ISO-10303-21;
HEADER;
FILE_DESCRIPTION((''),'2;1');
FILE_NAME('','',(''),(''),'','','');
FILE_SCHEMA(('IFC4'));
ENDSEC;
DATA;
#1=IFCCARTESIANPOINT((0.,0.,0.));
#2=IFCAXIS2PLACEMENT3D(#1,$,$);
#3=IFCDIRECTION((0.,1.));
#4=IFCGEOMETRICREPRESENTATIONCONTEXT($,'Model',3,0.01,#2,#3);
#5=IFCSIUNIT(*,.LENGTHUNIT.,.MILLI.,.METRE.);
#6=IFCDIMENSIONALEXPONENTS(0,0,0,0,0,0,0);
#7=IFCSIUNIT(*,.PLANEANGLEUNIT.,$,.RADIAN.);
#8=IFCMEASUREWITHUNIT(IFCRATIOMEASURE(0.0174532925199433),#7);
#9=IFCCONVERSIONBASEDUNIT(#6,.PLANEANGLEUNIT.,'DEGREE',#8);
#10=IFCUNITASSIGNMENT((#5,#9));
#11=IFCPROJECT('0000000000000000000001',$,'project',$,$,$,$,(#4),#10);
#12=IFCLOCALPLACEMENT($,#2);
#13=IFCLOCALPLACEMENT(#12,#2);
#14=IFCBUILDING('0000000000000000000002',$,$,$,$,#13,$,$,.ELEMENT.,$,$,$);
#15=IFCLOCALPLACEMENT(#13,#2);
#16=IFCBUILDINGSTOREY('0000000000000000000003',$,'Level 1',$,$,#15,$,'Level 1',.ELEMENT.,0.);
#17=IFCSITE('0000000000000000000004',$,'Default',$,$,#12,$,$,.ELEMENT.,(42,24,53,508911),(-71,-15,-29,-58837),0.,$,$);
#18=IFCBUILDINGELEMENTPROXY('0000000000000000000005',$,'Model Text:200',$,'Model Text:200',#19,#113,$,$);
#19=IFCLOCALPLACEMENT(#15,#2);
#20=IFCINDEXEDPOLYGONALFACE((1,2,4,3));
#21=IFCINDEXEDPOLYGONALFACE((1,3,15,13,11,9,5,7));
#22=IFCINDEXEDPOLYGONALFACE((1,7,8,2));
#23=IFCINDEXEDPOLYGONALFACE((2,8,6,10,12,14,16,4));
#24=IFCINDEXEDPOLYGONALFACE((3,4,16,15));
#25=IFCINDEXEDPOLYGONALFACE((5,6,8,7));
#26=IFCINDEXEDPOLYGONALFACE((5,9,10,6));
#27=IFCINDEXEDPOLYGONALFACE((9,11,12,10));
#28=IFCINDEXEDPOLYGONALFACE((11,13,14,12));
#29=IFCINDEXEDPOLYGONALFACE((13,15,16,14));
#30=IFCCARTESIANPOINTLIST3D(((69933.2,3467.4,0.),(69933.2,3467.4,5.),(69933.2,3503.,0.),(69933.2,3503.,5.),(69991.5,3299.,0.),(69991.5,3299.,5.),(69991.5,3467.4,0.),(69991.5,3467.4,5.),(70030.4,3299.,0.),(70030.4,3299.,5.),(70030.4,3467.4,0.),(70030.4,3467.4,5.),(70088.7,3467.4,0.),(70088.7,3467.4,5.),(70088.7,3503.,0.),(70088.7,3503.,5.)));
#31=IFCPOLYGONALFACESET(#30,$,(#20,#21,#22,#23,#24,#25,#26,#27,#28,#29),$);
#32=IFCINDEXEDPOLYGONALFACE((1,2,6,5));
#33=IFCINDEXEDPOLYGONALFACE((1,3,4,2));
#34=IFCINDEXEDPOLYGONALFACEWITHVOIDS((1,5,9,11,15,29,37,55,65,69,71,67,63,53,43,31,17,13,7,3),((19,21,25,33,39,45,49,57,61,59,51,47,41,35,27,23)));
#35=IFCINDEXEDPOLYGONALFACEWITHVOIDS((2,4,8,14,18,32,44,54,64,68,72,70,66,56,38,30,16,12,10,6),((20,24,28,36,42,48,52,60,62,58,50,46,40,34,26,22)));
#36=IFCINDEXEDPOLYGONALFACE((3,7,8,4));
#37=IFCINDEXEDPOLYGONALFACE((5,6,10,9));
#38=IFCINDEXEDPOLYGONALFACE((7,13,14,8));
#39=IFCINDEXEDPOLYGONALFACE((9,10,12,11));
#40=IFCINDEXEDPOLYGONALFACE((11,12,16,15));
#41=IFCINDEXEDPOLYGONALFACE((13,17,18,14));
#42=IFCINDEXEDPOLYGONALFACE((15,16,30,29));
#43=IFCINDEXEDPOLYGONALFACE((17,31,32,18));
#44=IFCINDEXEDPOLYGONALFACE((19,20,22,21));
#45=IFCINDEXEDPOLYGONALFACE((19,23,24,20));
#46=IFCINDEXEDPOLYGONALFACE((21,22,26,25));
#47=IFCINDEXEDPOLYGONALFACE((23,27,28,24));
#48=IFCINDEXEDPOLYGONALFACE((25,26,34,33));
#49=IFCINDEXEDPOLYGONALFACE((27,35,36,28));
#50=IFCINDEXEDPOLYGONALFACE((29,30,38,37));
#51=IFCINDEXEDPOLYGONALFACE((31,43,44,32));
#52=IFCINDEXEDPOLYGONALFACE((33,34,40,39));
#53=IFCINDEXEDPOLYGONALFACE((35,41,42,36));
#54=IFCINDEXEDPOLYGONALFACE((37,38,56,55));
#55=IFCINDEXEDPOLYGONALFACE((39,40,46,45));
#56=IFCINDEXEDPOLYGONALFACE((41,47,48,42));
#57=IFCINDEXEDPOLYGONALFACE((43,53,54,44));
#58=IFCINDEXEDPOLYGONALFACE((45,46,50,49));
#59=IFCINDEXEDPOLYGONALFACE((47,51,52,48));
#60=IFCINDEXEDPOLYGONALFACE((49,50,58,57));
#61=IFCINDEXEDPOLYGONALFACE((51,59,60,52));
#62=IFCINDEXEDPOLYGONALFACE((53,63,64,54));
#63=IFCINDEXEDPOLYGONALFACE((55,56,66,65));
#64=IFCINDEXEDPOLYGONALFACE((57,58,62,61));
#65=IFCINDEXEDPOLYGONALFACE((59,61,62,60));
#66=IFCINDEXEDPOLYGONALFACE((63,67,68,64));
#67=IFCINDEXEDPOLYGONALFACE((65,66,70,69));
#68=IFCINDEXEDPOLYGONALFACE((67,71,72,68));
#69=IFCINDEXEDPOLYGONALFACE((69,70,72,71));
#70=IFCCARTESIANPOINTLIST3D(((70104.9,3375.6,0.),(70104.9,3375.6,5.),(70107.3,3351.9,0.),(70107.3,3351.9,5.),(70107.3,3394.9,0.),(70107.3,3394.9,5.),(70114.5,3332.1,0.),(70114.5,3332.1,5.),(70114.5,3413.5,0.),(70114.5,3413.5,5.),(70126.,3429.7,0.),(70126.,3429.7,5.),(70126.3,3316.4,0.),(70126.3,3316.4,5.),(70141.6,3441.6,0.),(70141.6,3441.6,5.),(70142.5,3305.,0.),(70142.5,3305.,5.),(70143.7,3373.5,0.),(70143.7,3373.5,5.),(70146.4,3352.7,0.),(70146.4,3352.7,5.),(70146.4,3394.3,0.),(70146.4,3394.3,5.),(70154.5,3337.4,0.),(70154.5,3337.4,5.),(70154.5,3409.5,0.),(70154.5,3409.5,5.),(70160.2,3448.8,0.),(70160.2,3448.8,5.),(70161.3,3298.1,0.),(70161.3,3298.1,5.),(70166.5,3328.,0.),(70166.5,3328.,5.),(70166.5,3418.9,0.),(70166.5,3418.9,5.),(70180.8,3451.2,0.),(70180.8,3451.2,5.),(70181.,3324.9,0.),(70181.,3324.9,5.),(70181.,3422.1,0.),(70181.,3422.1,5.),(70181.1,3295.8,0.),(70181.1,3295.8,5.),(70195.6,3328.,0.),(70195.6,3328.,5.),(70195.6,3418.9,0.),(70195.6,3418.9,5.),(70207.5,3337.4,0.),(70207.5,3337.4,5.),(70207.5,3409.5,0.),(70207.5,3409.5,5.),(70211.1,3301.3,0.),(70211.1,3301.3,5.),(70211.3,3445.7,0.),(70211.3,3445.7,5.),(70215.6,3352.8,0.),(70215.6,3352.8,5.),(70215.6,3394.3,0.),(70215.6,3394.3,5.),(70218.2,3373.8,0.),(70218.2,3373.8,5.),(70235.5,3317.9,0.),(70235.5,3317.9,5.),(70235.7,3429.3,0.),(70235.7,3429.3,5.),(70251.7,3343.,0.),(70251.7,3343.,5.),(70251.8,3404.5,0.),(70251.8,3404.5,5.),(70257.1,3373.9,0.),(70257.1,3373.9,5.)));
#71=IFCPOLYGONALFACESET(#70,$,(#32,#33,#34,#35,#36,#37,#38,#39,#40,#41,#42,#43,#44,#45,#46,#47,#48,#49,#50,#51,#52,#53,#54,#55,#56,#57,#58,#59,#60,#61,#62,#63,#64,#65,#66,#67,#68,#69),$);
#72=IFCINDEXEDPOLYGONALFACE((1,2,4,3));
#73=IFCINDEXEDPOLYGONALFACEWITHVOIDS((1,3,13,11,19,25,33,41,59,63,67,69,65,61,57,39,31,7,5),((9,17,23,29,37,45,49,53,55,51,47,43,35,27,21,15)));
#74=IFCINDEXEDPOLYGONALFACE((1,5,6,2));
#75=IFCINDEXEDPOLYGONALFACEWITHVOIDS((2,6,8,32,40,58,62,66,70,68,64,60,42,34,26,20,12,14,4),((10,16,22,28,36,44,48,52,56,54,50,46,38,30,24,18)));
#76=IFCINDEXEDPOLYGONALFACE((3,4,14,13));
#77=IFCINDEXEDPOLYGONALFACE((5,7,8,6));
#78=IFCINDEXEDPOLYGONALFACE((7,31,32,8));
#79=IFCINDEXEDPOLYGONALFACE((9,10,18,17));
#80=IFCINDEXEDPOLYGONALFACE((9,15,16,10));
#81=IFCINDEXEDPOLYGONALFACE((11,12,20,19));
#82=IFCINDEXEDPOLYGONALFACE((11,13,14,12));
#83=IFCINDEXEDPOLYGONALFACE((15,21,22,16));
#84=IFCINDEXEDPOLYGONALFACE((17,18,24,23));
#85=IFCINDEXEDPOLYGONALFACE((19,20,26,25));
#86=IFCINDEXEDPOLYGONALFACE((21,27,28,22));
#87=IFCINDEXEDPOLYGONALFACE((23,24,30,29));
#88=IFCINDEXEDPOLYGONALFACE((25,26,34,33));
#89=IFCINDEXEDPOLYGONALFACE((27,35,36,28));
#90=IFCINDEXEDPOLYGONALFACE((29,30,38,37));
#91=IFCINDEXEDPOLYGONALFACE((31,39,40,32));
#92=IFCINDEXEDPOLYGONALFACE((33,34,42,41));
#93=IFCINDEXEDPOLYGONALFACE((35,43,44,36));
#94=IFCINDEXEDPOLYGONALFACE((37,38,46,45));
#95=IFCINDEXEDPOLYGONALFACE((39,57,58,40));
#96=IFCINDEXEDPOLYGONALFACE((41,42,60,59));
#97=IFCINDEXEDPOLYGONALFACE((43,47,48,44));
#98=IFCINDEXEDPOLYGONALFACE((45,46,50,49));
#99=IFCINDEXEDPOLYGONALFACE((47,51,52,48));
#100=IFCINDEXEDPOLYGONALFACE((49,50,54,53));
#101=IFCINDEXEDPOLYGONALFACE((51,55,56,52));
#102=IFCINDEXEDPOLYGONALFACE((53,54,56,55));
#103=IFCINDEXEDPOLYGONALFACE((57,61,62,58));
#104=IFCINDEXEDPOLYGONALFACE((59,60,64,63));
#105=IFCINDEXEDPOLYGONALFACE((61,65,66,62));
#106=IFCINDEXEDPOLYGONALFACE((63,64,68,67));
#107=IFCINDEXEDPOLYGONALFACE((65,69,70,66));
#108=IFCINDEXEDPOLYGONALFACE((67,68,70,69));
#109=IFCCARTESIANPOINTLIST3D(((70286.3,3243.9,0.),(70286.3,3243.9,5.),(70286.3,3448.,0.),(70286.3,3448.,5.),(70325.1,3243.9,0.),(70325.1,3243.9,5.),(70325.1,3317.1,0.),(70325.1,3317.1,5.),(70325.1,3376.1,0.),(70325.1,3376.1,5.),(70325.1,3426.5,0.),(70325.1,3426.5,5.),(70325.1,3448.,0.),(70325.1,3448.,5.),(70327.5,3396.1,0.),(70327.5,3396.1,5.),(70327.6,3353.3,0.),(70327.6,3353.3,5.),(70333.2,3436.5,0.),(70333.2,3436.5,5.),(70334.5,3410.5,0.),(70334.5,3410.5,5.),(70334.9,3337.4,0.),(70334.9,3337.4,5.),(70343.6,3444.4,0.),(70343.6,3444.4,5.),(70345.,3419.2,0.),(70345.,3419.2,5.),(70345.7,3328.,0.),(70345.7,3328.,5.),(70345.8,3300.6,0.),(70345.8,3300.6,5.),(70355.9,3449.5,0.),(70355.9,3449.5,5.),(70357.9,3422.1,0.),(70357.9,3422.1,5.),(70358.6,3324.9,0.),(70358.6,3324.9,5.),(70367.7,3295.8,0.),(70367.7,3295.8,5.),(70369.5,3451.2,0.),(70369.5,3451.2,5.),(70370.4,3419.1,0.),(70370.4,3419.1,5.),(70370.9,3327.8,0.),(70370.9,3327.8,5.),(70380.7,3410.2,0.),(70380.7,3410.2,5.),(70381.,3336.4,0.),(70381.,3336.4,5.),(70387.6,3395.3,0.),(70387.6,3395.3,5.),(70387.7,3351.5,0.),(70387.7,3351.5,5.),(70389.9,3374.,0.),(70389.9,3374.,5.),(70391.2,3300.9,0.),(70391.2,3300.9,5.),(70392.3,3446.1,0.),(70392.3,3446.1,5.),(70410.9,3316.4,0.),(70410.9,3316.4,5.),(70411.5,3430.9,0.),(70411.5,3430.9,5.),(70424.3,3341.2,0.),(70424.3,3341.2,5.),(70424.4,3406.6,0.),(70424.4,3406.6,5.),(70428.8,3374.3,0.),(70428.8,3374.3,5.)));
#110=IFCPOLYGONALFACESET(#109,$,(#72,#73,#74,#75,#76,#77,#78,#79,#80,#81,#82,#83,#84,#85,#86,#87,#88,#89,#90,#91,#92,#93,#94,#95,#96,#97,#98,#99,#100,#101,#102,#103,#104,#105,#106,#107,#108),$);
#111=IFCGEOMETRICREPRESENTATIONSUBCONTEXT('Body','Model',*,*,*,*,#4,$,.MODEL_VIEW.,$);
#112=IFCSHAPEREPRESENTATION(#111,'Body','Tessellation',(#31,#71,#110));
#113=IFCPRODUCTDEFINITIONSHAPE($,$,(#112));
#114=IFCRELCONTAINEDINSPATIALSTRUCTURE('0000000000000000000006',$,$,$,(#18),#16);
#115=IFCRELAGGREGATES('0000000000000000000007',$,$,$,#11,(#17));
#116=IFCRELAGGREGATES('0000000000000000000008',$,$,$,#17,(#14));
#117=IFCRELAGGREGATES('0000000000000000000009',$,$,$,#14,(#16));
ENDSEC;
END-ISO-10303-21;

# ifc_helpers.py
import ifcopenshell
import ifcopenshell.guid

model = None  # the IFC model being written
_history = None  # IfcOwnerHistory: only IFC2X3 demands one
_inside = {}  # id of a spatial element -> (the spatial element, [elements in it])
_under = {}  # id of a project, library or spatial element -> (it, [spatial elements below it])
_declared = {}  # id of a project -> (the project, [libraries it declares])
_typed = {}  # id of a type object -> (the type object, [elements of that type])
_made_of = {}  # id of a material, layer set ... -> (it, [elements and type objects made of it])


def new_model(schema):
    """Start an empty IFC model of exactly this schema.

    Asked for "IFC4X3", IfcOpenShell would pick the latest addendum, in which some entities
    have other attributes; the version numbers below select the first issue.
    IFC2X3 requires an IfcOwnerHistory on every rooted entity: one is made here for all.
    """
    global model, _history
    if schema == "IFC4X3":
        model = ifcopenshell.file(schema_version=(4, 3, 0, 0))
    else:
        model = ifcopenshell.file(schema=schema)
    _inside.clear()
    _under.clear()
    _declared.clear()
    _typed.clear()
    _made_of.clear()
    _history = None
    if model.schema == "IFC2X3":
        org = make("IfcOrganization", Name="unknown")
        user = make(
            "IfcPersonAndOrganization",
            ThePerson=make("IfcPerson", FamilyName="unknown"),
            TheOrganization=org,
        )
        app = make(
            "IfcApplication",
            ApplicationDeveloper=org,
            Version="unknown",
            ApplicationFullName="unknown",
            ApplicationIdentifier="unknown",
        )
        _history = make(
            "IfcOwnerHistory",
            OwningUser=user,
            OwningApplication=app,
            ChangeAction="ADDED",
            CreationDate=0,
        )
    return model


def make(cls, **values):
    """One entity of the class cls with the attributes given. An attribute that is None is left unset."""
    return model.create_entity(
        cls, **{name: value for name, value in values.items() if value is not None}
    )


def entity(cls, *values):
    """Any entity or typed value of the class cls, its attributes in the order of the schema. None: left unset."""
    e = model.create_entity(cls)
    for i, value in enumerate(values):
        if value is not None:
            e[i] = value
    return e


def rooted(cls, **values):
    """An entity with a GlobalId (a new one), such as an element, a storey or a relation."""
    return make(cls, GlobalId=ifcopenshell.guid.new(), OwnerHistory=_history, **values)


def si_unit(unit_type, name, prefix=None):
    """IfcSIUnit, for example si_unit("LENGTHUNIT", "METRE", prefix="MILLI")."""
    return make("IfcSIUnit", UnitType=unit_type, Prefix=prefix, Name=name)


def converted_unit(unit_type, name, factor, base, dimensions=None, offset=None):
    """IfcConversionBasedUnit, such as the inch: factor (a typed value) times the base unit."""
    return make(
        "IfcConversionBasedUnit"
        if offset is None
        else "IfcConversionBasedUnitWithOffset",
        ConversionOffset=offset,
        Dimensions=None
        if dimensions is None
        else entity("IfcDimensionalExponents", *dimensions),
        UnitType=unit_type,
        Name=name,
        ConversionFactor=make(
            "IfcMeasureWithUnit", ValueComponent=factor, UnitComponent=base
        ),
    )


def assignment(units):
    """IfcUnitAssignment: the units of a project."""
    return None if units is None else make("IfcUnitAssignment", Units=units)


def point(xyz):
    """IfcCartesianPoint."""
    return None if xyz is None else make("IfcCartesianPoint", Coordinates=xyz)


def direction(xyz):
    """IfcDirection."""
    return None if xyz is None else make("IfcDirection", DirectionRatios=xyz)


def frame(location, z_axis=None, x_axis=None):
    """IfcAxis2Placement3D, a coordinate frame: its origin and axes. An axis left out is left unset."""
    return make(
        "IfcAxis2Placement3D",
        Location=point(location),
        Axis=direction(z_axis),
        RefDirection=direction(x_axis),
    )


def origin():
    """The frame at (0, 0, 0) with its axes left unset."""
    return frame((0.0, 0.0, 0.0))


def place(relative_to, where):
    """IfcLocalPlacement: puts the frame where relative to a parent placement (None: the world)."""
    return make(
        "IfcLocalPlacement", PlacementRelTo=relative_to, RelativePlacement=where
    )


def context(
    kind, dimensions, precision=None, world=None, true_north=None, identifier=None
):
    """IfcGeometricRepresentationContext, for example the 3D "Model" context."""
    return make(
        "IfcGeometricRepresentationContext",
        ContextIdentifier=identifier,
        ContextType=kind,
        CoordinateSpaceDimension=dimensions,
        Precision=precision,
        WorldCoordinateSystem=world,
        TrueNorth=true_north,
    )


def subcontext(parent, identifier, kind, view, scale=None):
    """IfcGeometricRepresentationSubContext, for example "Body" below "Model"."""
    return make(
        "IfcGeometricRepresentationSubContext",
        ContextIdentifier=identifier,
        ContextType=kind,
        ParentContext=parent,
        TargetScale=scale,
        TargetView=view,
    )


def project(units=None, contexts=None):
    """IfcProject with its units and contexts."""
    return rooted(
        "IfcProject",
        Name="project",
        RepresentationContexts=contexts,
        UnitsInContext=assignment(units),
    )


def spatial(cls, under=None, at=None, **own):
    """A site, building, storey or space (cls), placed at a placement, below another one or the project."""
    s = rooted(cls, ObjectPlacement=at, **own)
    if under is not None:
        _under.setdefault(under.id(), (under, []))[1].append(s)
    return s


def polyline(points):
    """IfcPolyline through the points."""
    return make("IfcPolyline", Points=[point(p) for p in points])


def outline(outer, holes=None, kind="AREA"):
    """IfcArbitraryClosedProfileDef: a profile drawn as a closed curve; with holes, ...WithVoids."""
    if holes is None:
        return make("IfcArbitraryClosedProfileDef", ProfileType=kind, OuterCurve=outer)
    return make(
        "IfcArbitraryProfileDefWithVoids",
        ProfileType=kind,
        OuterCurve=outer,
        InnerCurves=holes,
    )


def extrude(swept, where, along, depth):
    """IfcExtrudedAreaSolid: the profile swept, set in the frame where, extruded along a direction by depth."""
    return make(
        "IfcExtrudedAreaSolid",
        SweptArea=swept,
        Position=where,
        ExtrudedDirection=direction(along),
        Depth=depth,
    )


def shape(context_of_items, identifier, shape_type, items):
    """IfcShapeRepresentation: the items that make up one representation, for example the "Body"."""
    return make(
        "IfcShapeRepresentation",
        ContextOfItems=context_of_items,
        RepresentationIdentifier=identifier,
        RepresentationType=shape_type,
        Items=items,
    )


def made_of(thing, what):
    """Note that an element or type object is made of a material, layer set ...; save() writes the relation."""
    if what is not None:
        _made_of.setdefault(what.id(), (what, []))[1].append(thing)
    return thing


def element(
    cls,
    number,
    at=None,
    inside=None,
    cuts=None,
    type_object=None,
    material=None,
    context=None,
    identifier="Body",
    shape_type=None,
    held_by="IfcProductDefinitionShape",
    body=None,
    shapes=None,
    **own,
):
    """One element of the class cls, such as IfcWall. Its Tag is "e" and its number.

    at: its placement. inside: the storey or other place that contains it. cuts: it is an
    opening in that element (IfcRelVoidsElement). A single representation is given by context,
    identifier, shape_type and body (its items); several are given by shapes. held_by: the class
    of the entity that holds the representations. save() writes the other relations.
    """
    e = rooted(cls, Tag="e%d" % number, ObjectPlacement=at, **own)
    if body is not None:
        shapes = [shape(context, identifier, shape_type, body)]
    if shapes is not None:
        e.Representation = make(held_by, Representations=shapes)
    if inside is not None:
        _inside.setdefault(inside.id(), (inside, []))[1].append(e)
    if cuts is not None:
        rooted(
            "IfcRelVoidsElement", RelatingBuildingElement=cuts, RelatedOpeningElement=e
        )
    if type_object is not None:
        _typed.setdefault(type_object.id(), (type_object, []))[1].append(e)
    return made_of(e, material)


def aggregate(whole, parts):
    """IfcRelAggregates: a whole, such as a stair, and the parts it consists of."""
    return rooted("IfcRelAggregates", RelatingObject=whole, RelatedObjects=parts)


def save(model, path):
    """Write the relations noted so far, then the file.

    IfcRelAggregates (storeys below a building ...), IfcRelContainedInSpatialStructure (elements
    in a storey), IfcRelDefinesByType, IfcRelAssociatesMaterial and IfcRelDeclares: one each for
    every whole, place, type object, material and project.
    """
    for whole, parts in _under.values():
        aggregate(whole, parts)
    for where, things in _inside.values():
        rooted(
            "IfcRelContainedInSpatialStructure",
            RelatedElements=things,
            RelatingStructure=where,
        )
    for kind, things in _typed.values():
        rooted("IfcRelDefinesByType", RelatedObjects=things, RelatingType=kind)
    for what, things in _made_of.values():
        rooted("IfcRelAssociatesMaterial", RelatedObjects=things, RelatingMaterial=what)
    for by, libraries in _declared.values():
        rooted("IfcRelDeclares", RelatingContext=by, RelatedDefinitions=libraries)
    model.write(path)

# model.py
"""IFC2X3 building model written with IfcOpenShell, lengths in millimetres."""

from ifc_helpers import new_model, entity, si_unit, converted_unit, direction, frame, origin, place, context, subcontext, project, spatial, polyline, outline, extrude, element, save


model = new_model("IFC2X3")

# Units and contexts
model_context = context("Model", 3, precision=0.01, world=origin(), true_north=direction((0.0, 1.0)))
body_context = subcontext(model_context, "Body", "Model", "MODEL_VIEW")
ifc_project = project(units=[si_unit("LENGTHUNIT", "METRE", prefix="MILLI"), converted_unit("PLANEANGLEUNIT", "DEGREE", entity("IfcRatioMeasure", 0.0174532925199433), si_unit("PLANEANGLEUNIT", "RADIAN"), dimensions=[0, 0, 0, 0, 0, 0, 0])], contexts=[model_context])

# Site, building, storey
site_placement = place(None, origin())
site = spatial("IfcSite", under=ifc_project, at=site_placement, Name="Default", CompositionType="ELEMENT", RefLatitude=(42, 24, 53, 508911), RefLongitude=(-71, -15, -29, -58837), RefElevation=0.0)
building_placement = place(site_placement, origin())
building = spatial("IfcBuilding", under=site, at=building_placement, CompositionType="ELEMENT")
storey_placement = place(building_placement, origin())
storey = spatial("IfcBuildingStorey", under=building, at=storey_placement, Name="Level 1", LongName="Level 1", CompositionType="ELEMENT", Elevation=0.0)

# Building element proxy
proxy_1_placement = place(storey_placement, origin())
element("IfcBuildingElementProxy", 1, at=proxy_1_placement, inside=storey, Name="Model Text:200", ObjectType="Model Text:200", context=body_context, shape_type="SweptSolid", body=[
    extrude(outline(polyline([(-19.4, -135.2), (19.4, -135.2), (19.4, 33.2), (77.7, 33.2), (77.7, 68.8), (-77.7, 68.8), (-77.7, 33.2), (-19.4, 33.2), (-19.4, -135.2)])), frame((70010.9, 3434.2, 0.0)), (0.0, 0.0, 1.0), 5.0),
    extrude(outline(polyline([(-8.8, -65.7), (15.1, -65.7), (35.5, -60.5), (52.3, -50.4), (65.3, -35.4), (74.1, -17.3), (78.4, 2.1), (75.9, 32.5), (61.8, 58.5), (38.4, 77.1), (8.3, 85.6), (-22.7, 83.3), (-49.0, 69.9), (-67.8, 47.3), (-76.3, 17.5), (-76.0, -3.3), (-70.7, -22.5), (-60.5, -39.2), (-45.5, -52.3), (-27.7, -61.4), (-8.8, -65.7)]), holes=[polyline([(-2.7, -27.2), (-23.1, -22.5), (-37.5, -12.9), (-45.7, 0.0), (-47.3, 14.8), (-42.7, 28.9), (-32.2, 39.9), (-16.3, 46.3), (4.5, 46.9), (25.1, 42.1), (39.6, 32.6), (47.7, 19.7), (49.4, 5.0), (44.8, -9.2), (34.2, -20.2), (18.2, -26.7), (-2.7, -27.2)])]), frame((70171.1, 3373.5, 0.0), z_axis=(0.0, 0.0, 1.0), x_axis=(0.100608, -0.994926, 0.0)), (0.0, 0.0, 1.0), 5.0),
    extrude(outline(polyline([(-73.1, -75.4), (130.9, -75.4), (130.9, -36.6), (57.8, -36.6), (74.3, -15.9), (79.1, 6.0), (73.9, 29.5), (58.4, 49.2), (33.6, 62.6), (0.5, 67.1), (-31.8, 62.8), (-56.1, 49.8), (-71.3, 30.7), (-76.4, 7.8), (-74.7, -5.8), (-69.6, -18.1), (-61.7, -28.5), (-51.7, -36.6), (-73.1, -36.6), (-73.1, -75.4)]), holes=[polyline([(-1.2, -36.6), (-21.2, -34.2), (-35.6, -27.2), (-44.3, -16.7), (-47.2, -3.8), (-44.3, 8.7), (-35.4, 19.0), (-20.4, 25.9), (0.8, 28.2), (23.3, 26.0), (38.5, 19.3), (47.1, 9.2), (49.9, -3.1), (46.8, -16.0), (37.4, -26.8), (21.5, -34.1), (-1.2, -36.6)])]), frame((70361.7, 3374.8, 0.0), z_axis=(0.0, 0.0, 1.0), x_axis=(0.0, -1.0, 0.0)), (0.0, 0.0, 1.0), 5.0),
])

save(model, "model.ifc")
